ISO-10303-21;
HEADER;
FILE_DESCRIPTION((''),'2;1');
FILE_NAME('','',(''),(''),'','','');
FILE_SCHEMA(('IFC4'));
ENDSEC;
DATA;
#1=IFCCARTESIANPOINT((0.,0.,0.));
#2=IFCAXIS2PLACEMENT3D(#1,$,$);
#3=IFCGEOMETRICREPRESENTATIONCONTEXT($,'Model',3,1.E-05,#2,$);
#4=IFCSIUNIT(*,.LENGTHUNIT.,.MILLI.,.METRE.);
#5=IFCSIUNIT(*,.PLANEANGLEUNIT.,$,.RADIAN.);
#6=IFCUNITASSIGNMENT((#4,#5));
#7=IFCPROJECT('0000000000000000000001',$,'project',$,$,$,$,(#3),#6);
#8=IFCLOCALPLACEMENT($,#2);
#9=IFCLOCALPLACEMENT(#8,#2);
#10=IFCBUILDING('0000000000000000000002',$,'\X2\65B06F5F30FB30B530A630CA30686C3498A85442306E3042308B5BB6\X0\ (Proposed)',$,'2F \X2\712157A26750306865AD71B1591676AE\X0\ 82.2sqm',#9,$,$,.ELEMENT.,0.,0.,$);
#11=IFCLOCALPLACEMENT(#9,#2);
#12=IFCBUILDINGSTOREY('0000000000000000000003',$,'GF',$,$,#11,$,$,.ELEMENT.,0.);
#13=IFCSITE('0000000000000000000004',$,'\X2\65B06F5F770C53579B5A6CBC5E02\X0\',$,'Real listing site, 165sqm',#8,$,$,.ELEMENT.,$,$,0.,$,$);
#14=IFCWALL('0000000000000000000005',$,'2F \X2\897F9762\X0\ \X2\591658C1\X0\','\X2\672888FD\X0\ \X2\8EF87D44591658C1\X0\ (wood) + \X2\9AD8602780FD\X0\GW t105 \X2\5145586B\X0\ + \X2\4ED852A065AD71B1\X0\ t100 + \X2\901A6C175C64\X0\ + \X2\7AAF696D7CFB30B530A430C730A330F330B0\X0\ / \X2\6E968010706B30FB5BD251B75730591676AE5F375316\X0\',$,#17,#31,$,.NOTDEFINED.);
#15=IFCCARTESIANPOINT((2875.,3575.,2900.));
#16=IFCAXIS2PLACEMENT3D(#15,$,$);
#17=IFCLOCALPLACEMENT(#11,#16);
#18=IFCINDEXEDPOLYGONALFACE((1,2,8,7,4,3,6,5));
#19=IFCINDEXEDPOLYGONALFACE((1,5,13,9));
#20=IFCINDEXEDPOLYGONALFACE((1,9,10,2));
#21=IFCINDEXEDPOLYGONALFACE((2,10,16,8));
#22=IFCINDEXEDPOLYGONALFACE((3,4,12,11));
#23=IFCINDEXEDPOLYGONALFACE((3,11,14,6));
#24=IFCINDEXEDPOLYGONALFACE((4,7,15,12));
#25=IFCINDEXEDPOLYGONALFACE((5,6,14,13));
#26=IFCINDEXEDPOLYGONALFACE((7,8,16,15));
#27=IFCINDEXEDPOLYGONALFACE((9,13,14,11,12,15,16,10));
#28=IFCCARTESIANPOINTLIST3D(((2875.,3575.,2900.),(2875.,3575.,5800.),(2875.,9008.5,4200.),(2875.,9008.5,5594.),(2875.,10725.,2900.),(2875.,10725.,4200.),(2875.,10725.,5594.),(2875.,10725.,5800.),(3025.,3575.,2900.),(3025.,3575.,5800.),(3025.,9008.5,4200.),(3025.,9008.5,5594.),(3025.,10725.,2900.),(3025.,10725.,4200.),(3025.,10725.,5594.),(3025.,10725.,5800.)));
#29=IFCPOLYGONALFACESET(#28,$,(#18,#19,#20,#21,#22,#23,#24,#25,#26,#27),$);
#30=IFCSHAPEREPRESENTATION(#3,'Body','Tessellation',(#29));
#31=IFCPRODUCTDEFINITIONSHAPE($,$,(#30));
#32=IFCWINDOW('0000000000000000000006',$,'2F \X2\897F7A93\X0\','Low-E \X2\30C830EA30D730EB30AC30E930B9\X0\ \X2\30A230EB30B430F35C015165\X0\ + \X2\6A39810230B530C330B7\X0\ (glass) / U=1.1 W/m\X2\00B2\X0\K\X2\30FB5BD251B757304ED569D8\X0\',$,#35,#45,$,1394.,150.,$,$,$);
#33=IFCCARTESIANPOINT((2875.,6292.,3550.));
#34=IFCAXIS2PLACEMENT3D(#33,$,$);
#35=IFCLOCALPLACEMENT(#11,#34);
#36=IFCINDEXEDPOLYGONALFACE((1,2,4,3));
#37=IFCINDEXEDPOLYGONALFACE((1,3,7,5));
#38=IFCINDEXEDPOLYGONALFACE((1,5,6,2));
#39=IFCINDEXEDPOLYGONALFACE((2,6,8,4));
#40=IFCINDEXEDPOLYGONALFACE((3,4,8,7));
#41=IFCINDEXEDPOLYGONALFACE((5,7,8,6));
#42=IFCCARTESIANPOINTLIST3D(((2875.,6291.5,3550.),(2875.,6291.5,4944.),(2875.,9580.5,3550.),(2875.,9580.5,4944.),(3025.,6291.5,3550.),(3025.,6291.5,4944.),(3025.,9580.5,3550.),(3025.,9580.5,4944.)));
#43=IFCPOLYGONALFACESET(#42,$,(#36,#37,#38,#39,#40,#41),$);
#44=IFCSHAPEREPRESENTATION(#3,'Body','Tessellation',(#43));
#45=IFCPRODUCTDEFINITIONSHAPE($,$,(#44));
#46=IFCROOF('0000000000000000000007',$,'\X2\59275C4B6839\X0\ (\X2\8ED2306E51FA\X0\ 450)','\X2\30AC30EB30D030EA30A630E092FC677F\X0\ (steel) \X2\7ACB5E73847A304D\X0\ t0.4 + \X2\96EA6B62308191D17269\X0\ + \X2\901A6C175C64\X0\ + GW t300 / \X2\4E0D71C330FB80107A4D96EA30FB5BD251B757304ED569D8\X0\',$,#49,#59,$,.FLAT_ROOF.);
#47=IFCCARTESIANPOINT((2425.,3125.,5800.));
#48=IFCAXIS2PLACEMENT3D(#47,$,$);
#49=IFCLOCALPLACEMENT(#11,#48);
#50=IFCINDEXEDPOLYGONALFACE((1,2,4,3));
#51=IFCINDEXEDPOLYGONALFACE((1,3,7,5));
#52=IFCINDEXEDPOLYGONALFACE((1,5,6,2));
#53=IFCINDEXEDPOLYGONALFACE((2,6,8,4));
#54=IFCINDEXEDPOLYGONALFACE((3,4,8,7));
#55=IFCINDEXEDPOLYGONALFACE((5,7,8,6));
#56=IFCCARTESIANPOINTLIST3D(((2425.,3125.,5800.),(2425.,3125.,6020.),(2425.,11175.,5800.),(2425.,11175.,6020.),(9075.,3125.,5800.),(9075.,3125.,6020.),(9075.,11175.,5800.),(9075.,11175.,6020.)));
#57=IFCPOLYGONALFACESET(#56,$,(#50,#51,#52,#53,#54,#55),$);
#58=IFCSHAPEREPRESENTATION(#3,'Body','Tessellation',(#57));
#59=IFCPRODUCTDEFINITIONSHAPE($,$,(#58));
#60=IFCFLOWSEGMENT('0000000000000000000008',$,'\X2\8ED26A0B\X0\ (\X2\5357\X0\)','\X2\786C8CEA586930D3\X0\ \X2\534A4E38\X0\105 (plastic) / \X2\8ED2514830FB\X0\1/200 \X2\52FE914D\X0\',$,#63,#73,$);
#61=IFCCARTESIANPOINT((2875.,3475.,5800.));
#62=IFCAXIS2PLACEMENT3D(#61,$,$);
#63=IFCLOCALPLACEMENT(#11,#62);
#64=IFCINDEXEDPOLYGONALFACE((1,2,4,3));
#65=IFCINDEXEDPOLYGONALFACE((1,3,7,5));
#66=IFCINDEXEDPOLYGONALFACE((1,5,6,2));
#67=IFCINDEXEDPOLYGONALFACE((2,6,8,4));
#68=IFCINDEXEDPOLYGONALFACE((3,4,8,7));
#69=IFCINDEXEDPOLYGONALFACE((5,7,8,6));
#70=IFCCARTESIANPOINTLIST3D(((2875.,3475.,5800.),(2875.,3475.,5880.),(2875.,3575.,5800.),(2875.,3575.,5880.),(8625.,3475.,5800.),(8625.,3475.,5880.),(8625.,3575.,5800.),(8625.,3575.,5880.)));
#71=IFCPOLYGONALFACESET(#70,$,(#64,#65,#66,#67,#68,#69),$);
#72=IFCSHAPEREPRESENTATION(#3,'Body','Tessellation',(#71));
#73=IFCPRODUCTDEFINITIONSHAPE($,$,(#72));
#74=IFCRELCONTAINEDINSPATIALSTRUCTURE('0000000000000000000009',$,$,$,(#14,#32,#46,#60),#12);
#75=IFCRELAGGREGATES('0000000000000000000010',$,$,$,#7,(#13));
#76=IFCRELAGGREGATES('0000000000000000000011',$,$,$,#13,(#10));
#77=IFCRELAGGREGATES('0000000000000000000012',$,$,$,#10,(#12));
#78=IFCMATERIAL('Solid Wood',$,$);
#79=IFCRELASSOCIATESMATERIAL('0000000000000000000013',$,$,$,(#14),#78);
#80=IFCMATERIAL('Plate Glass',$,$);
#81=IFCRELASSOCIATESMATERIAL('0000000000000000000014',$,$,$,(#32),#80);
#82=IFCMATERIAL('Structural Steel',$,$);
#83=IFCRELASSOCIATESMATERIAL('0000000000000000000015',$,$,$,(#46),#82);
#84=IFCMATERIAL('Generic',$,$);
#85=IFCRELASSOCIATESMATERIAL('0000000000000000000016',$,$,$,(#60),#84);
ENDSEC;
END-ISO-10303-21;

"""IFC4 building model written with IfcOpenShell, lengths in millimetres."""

from ifc_helpers import new_model, si_unit, frame, frame_2d, origin, place, context, project, spatial, rectangle, extrude, material, element, fill, save


model = new_model("IFC4")

# Units and contexts
model_context = context("Model", 3, precision=1e-05, world=origin())
ifc_project = project(units=[si_unit("LENGTHUNIT", "METRE", prefix="MILLI"), si_unit("PLANEANGLEUNIT", "RADIAN")], contexts=[model_context])

# Site, building, storey
site_placement = place(None, origin())
site = spatial("IfcSite", under=ifc_project, at=site_placement, Name="新潟県南魚沼市", ObjectType="Real listing site, 165sqm", CompositionType="ELEMENT", RefElevation=0.0)
building_placement = place(site_placement, origin())
building = spatial("IfcBuilding", under=site, at=building_placement, Name="新潟・サウナと水風呂のある家 (Proposed)", ObjectType="2F 無垢材と断熱外皮 82.2sqm", CompositionType="ELEMENT", ElevationOfRefHeight=0.0, ElevationOfTerrain=0.0)
storey_placement = place(building_placement, origin())
storey = spatial("IfcBuildingStorey", under=building, at=storey_placement, Name="GF", CompositionType="ELEMENT", Elevation=0.0)

# Shared definitions
ifc_material_1 = material(Name="Solid Wood")

# Shared definitions
ifc_material_2 = material(Name="Plate Glass")

# Wall, opening, window
wall_1_placement = place(storey_placement, frame((2875.0, 3575.0, 2900.0)))
wall_1 = element("IfcWall", 1, at=wall_1_placement, inside=storey, material=ifc_material_1, Name="2F 西面 外壁", Description="木製 軸組外壁 (wood) + 高性能GW t105 充填 + 付加断熱 t100 + 通気層 + 窯業系サイディング / 準耐火・寒冷地外皮強化", PredefinedType="NOTDEFINED", context=model_context, shape_type="SweptSolid", body=[
    extrude(rectangle(XDim=150.0, YDim=7150.0, at=frame_2d((75.0, 3575.0))), frame((2875.0, 3575.0, 2900.0)), (0.0, 0.0, 1.0), 2900.0),
])
opening_1_placement = place(storey_placement, frame((2875.0, 6292.0, 3550.0)))
opening_1 = element("IfcOpeningElement", 2, at=opening_1_placement, cuts=wall_1, PredefinedType="NOTDEFINED", context=model_context, shape_type="SweptSolid", body=[
    extrude(rectangle(XDim=150.0, YDim=3289.0, at=frame_2d((75.0, 1644.0))), frame((2875.0, 6292.0, 3550.0)), (0.0, 0.0, 1.0), 1394.0),
])
window_1_placement = place(storey_placement, frame((2875.0, 6292.0, 3550.0)))
window_1 = element("IfcWindow", 3, at=window_1_placement, inside=storey, material=ifc_material_2, Name="2F 西窓", Description="Low-E トリプルガラス アルゴン封入 + 樹脂サッシ (glass) / U=1.1 W/m²K・寒冷地仕様", OverallHeight=1394.0, OverallWidth=150.0, context=model_context, shape_type="SweptSolid", body=[
    extrude(rectangle(XDim=150.0, YDim=3289.0, at=frame_2d((75.0, 1644.0))), frame((2875.0, 6292.0, 3550.0)), (0.0, 0.0, 1.0), 1394.0),
])
fill(opening_1, window_1)

# Roof
ifc_material_3 = material(Name="Structural Steel")
roof_placement = place(storey_placement, frame((2425.0, 3125.0, 5800.0)))
element("IfcRoof", 4, at=roof_placement, inside=storey, material=ifc_material_3, Name="大屋根 (軒の出 450)", Description="ガルバリウム鋼板 (steel) 立平葺き t0.4 + 雪止め金物 + 通気層 + GW t300 / 不燃・耐積雪・寒冷地仕様", PredefinedType="FLAT_ROOF", context=model_context, shape_type="SweptSolid", body=[
    extrude(rectangle(XDim=6650.0, YDim=8050.0, at=frame_2d((3325.0, 4025.0))), frame((2425.0, 3125.0, 5800.0)), (0.0, 0.0, 1.0), 220.0),
])

# Flow segment
ifc_material_4 = material(Name="Generic")
flow_segment_placement = place(storey_placement, frame((2875.0, 3475.0, 5800.0)))
element("IfcFlowSegment", 5, at=flow_segment_placement, inside=storey, material=ifc_material_4, Name="軒樋 (南)", Description="硬質塩ビ 半丸105 (plastic) / 軒先・1/200 勾配", context=model_context, shape_type="SweptSolid", body=[
    extrude(rectangle(XDim=5750.0, YDim=100.0, at=frame_2d((2875.0, 50.0))), frame((2875.0, 3475.0, 5800.0)), (0.0, 0.0, 1.0), 80.0),
])

save(model, "model.ifc")
